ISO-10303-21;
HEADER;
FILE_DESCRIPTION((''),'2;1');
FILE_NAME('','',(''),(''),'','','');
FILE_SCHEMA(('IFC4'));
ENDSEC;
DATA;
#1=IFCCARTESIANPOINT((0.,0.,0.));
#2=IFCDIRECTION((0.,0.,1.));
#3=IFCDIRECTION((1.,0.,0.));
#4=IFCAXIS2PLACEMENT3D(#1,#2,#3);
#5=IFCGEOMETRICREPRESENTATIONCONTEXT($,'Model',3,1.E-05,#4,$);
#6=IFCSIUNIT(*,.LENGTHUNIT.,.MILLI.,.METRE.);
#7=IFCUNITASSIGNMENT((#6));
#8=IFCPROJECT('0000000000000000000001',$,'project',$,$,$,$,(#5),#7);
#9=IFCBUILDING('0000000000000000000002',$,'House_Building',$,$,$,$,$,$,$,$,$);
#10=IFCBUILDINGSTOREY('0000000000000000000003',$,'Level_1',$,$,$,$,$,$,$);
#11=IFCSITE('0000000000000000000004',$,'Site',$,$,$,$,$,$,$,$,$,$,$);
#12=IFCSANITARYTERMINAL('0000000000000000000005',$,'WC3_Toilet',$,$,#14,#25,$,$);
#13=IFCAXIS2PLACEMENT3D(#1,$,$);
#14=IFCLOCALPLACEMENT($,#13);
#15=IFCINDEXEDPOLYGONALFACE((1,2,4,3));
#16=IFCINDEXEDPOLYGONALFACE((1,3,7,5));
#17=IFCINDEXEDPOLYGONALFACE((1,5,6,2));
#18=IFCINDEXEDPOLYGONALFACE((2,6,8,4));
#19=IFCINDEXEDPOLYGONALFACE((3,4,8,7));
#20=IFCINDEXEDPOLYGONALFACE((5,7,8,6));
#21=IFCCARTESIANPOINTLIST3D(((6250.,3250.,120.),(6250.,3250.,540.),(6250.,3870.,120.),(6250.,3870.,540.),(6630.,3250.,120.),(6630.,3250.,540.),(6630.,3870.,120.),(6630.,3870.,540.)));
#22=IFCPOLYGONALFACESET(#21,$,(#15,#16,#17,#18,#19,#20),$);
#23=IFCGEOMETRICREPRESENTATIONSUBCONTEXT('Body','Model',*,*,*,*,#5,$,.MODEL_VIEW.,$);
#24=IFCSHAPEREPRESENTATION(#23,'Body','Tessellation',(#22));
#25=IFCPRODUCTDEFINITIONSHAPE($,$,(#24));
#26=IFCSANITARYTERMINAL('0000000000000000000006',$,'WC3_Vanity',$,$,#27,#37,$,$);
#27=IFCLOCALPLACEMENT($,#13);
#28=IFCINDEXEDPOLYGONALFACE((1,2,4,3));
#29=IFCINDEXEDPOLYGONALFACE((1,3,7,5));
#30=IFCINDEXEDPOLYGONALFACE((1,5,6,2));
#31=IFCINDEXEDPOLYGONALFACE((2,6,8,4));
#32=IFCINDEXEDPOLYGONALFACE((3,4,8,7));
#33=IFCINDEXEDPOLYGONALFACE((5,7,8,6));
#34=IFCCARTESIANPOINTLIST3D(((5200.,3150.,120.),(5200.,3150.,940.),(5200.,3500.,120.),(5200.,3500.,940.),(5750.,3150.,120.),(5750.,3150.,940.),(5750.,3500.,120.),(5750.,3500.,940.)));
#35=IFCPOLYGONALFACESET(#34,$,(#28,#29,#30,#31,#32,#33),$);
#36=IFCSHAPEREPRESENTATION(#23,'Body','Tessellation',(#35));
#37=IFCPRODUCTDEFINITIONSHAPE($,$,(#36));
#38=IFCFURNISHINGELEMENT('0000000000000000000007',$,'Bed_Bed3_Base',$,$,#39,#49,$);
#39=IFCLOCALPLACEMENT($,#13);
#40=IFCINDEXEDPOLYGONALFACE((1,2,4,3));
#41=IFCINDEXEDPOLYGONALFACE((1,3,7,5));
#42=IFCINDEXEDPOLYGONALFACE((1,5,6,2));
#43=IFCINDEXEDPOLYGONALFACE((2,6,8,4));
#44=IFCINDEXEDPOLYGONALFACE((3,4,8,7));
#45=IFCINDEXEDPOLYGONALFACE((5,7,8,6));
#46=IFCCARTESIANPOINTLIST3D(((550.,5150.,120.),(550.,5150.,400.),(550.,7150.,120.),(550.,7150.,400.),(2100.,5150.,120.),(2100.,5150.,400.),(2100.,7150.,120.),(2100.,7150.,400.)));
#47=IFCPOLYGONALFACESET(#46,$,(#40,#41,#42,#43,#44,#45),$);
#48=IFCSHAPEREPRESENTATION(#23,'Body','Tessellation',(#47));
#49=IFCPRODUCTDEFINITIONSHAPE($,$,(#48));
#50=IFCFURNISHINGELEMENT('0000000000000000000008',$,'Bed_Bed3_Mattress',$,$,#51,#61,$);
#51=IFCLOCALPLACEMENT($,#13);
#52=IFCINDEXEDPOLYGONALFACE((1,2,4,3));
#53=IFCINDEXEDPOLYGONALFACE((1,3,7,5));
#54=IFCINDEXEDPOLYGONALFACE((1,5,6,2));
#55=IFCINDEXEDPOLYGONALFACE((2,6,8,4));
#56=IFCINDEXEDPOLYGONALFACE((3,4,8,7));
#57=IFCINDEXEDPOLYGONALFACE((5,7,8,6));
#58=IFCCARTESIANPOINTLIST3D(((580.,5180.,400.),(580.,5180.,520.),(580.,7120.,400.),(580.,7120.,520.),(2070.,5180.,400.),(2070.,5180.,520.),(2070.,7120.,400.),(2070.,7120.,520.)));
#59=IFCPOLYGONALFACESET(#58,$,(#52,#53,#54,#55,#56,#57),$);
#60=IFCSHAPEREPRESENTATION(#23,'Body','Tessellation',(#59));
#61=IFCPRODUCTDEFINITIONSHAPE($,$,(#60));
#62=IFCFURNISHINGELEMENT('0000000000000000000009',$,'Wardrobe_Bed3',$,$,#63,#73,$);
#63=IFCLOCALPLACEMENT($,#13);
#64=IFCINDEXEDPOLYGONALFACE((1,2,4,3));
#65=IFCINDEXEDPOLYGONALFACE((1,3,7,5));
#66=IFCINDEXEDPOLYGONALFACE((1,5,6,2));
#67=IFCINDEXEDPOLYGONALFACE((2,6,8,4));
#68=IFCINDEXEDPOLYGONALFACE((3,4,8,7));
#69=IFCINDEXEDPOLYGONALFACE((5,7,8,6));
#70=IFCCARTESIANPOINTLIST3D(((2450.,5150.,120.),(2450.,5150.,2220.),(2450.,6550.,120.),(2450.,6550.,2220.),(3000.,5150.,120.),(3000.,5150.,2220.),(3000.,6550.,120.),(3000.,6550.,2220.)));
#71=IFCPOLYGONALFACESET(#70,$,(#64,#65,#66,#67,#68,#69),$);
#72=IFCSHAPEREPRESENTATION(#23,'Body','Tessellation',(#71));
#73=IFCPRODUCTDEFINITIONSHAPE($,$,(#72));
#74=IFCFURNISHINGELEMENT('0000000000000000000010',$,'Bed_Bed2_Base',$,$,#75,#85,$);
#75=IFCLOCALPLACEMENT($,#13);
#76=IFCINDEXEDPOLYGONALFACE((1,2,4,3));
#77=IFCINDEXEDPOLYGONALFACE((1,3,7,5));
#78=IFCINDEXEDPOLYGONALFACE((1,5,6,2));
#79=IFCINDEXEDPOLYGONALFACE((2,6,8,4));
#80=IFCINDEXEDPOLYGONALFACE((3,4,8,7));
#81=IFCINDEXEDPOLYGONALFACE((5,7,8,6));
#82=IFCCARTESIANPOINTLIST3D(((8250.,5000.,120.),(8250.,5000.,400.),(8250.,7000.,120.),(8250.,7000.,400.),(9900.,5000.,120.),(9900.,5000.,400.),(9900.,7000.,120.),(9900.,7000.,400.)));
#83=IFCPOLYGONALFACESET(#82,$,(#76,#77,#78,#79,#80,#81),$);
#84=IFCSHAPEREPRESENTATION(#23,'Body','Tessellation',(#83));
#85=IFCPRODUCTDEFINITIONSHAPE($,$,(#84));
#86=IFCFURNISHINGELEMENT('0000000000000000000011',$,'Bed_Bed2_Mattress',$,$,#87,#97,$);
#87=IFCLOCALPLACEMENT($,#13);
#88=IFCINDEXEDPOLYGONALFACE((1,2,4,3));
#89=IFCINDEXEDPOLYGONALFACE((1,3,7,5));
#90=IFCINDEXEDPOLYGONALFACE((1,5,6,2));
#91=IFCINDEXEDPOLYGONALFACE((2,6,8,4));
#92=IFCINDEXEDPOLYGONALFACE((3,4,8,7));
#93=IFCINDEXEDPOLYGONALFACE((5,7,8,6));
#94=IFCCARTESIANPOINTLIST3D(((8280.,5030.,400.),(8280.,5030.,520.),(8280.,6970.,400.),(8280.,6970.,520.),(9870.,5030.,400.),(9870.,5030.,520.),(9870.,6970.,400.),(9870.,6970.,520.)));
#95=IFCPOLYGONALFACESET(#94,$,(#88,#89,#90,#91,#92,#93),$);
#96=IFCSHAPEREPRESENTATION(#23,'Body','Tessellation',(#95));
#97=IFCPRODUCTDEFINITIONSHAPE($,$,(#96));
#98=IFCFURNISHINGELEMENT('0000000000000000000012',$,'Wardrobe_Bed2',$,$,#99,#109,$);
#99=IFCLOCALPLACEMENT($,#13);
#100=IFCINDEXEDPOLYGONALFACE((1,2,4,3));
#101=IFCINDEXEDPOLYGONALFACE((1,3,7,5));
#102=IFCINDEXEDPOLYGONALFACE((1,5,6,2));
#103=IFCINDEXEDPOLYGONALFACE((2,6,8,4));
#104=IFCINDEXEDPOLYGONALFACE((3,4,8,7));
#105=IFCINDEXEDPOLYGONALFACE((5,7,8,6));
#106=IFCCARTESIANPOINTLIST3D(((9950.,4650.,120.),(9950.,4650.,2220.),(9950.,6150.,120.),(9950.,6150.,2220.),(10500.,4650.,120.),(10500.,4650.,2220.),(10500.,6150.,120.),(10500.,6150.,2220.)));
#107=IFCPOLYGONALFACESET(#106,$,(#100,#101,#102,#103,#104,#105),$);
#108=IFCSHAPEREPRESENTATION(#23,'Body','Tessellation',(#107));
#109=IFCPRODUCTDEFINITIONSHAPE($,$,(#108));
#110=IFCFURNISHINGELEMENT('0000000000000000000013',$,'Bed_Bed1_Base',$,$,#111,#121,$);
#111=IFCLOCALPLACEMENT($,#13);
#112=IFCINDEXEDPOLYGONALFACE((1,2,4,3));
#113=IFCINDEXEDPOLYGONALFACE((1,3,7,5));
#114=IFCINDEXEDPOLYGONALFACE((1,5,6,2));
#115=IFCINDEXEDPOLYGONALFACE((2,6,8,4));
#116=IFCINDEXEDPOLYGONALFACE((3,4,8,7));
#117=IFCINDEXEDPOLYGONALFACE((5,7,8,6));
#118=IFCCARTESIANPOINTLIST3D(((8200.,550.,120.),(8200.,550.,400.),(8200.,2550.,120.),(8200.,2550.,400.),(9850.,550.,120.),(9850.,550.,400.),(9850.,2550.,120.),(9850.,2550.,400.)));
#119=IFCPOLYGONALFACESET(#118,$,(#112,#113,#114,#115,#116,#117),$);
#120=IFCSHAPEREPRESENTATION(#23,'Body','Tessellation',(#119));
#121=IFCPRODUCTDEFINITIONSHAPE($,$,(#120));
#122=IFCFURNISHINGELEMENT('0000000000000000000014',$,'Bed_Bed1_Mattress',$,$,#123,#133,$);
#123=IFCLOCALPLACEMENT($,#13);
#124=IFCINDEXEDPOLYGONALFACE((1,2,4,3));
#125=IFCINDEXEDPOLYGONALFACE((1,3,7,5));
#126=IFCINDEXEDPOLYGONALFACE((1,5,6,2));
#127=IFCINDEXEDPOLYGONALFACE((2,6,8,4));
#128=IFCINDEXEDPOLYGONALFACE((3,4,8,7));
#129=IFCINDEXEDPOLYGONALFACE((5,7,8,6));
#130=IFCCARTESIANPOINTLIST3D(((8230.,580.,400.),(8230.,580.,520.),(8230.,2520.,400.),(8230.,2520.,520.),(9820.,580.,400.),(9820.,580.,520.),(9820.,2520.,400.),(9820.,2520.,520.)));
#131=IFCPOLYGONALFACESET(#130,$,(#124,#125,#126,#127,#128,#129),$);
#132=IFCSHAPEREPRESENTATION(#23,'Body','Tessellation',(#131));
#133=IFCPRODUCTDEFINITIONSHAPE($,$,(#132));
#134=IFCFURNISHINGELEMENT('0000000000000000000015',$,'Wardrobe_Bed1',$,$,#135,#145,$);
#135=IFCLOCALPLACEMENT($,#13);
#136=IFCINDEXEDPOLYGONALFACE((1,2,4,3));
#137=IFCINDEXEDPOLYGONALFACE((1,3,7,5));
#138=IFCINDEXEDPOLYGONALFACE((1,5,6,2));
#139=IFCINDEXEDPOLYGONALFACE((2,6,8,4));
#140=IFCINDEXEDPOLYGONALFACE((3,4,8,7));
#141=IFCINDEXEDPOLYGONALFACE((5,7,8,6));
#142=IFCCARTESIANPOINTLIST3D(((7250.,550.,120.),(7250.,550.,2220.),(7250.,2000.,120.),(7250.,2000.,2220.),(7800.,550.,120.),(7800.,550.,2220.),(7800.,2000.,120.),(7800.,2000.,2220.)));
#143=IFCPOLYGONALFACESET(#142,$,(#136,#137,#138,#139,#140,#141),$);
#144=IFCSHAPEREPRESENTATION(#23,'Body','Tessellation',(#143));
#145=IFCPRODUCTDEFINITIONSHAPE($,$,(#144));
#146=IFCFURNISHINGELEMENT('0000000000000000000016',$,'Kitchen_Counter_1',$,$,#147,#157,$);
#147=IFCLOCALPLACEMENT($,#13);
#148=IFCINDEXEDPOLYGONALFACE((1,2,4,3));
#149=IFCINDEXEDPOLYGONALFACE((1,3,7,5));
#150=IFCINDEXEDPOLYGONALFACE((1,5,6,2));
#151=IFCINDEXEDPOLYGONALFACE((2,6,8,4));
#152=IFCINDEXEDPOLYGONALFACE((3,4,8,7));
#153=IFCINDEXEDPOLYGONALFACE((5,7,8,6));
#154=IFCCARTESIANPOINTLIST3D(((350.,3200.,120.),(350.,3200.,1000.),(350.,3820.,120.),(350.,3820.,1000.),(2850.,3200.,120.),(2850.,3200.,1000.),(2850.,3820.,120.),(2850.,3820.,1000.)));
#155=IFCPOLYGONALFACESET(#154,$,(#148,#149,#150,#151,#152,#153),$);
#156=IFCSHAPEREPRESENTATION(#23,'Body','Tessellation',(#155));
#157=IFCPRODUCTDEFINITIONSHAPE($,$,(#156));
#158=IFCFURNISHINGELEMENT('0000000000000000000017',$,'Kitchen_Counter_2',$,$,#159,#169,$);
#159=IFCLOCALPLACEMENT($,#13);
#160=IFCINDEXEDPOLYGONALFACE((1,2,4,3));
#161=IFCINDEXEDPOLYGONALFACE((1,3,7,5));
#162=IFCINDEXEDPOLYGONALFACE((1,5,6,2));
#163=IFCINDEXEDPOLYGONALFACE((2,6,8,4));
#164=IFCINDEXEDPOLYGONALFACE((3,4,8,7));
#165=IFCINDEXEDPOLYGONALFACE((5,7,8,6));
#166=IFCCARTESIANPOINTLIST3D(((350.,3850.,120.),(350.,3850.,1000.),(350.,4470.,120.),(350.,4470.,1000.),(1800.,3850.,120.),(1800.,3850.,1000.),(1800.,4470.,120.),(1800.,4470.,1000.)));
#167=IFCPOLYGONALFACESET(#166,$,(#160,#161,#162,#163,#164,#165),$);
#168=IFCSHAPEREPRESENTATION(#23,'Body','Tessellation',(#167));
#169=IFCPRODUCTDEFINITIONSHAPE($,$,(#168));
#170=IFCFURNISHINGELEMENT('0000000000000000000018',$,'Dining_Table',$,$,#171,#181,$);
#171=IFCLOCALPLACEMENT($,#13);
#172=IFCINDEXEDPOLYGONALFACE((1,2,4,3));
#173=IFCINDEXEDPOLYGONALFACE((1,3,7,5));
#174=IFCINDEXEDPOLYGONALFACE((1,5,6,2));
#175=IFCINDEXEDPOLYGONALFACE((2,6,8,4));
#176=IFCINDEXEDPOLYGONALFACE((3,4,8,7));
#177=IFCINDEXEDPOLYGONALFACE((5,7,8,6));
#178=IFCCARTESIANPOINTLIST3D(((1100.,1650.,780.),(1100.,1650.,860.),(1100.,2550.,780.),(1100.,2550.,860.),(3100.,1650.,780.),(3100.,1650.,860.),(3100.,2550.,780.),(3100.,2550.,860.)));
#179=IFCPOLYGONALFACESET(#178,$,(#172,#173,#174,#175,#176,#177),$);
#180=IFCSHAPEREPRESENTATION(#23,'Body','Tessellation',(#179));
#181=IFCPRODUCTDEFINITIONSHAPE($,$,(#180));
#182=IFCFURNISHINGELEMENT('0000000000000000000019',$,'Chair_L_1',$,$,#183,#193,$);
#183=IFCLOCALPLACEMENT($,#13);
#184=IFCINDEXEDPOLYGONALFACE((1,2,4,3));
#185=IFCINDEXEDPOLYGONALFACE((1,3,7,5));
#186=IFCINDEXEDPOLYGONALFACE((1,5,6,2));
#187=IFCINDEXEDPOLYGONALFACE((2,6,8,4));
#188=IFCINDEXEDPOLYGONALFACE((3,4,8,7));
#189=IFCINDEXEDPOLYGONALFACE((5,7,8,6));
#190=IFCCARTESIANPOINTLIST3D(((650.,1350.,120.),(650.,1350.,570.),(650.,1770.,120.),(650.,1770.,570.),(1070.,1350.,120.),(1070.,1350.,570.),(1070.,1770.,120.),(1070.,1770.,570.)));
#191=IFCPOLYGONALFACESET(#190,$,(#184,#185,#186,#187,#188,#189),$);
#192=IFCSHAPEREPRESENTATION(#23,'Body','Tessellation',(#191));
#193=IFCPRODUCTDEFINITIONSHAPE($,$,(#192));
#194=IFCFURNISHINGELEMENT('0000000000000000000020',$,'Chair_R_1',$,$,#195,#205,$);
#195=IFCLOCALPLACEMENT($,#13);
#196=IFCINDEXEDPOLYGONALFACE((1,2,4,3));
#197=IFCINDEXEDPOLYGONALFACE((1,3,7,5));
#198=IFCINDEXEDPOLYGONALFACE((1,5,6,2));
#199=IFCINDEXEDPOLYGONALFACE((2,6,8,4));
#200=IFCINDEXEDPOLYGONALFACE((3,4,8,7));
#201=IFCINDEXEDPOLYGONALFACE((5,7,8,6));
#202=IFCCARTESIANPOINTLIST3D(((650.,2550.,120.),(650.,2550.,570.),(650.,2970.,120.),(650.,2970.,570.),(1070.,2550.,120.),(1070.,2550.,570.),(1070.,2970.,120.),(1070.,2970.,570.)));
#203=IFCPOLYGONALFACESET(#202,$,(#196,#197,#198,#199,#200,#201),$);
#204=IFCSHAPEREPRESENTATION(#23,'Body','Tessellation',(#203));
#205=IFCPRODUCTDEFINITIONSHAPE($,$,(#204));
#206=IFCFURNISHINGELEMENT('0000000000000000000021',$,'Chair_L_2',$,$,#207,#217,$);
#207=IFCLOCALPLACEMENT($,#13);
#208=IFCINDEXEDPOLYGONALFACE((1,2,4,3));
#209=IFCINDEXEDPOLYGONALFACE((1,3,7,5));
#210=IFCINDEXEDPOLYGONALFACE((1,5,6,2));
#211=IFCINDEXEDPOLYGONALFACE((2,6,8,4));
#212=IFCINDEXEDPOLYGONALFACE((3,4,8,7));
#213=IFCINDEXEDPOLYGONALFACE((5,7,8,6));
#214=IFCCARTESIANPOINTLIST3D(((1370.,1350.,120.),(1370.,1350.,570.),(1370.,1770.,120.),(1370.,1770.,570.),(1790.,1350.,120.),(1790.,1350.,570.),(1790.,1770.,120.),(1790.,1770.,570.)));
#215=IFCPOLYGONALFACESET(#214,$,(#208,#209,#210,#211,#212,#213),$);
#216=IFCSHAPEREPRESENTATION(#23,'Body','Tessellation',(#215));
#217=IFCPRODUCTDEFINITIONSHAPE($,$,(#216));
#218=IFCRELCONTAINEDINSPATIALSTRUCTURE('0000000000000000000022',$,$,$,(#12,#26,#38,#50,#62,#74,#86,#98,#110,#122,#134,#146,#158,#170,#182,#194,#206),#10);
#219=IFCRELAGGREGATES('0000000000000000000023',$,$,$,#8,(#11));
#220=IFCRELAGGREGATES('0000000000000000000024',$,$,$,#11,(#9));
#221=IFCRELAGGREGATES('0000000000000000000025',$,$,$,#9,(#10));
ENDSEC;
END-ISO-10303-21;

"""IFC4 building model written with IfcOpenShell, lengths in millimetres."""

from ifc_helpers import new_model, si_unit, frame, origin_with_axes, context, subcontext, project, spatial, polyline, outline, extrude, element, save


model = new_model("IFC4")

# Units and contexts
model_context = context("Model", 3, precision=1e-05, world=origin_with_axes())
body_context = subcontext(model_context, "Body", "Model", "MODEL_VIEW")
ifc_project = project(units=[si_unit("LENGTHUNIT", "METRE", prefix="MILLI")], contexts=[model_context])

# Site, building, storey
site = spatial("IfcSite", under=ifc_project, Name="Site")
building = spatial("IfcBuilding", under=site, Name="House_Building")
storey = spatial("IfcBuildingStorey", under=building, Name="Level_1")

# Sanitary terminals
element("IfcSanitaryTerminal", 1, inside=storey, Name="WC3_Toilet", context=body_context, shape_type="SweptSolid", body=[
    extrude(outline(polyline([(6250.0, 3250.0), (6630.0, 3250.0), (6630.0, 3870.0), (6250.0, 3870.0), (6250.0, 3250.0)])), frame((0.0, 0.0, 120.0), z_axis=(0.0, 0.0, 1.0), x_axis=(1.0, 0.0, 0.0)), (0.0, 0.0, 1.0), 420.0),
])
element("IfcSanitaryTerminal", 2, inside=storey, Name="WC3_Vanity", context=body_context, shape_type="SweptSolid", body=[
    extrude(outline(polyline([(5200.0, 3150.0), (5750.0, 3150.0), (5750.0, 3500.0), (5200.0, 3500.0), (5200.0, 3150.0)])), frame((0.0, 0.0, 120.0), z_axis=(0.0, 0.0, 1.0), x_axis=(1.0, 0.0, 0.0)), (0.0, 0.0, 1.0), 820.0),
])

# Furnishing elements
element("IfcFurnishingElement", 3, inside=storey, Name="Bed_Bed3_Base", context=body_context, shape_type="SweptSolid", body=[
    extrude(outline(polyline([(550.0, 5150.0), (2100.0, 5150.0), (2100.0, 7150.0), (550.0, 7150.0), (550.0, 5150.0)])), frame((0.0, 0.0, 120.0), z_axis=(0.0, 0.0, 1.0), x_axis=(1.0, 0.0, 0.0)), (0.0, 0.0, 1.0), 280.0),
])
element("IfcFurnishingElement", 4, inside=storey, Name="Bed_Bed3_Mattress", context=body_context, shape_type="SweptSolid", body=[
    extrude(outline(polyline([(580.0, 5180.0), (2070.0, 5180.0), (2070.0, 7120.0), (580.0, 7120.0), (580.0, 5180.0)])), frame((0.0, 0.0, 400.0), z_axis=(0.0, 0.0, 1.0), x_axis=(1.0, 0.0, 0.0)), (0.0, 0.0, 1.0), 120.0),
])
element("IfcFurnishingElement", 5, inside=storey, Name="Wardrobe_Bed3", context=body_context, shape_type="SweptSolid", body=[
    extrude(outline(polyline([(2450.0, 5150.0), (3000.0, 5150.0), (3000.0, 6550.0), (2450.0, 6550.0), (2450.0, 5150.0)])), frame((0.0, 0.0, 120.0), z_axis=(0.0, 0.0, 1.0), x_axis=(1.0, 0.0, 0.0)), (0.0, 0.0, 1.0), 2100.0),
])
element("IfcFurnishingElement", 6, inside=storey, Name="Bed_Bed2_Base", context=body_context, shape_type="SweptSolid", body=[
    extrude(outline(polyline([(8250.0, 5000.0), (9900.0, 5000.0), (9900.0, 7000.0), (8250.0, 7000.0), (8250.0, 5000.0)])), frame((0.0, 0.0, 120.0), z_axis=(0.0, 0.0, 1.0), x_axis=(1.0, 0.0, 0.0)), (0.0, 0.0, 1.0), 280.0),
])
element("IfcFurnishingElement", 7, inside=storey, Name="Bed_Bed2_Mattress", context=body_context, shape_type="SweptSolid", body=[
    extrude(outline(polyline([(8280.0, 5030.0), (9870.0, 5030.0), (9870.0, 6970.0), (8280.0, 6970.0), (8280.0, 5030.0)])), frame((0.0, 0.0, 400.0), z_axis=(0.0, 0.0, 1.0), x_axis=(1.0, 0.0, 0.0)), (0.0, 0.0, 1.0), 120.0),
])
element("IfcFurnishingElement", 8, inside=storey, Name="Wardrobe_Bed2", context=body_context, shape_type="SweptSolid", body=[
    extrude(outline(polyline([(9950.0, 4650.0), (10500.0, 4650.0), (10500.0, 6150.0), (9950.0, 6150.0), (9950.0, 4650.0)])), frame((0.0, 0.0, 120.0), z_axis=(0.0, 0.0, 1.0), x_axis=(1.0, 0.0, 0.0)), (0.0, 0.0, 1.0), 2100.0),
])
element("IfcFurnishingElement", 9, inside=storey, Name="Bed_Bed1_Base", context=body_context, shape_type="SweptSolid", body=[
    extrude(outline(polyline([(8200.0, 550.0), (9850.0, 550.0), (9850.0, 2550.0), (8200.0, 2550.0), (8200.0, 550.0)])), frame((0.0, 0.0, 120.0), z_axis=(0.0, 0.0, 1.0), x_axis=(1.0, 0.0, 0.0)), (0.0, 0.0, 1.0), 280.0),
])
element("IfcFurnishingElement", 10, inside=storey, Name="Bed_Bed1_Mattress", context=body_context, shape_type="SweptSolid", body=[
    extrude(outline(polyline([(8230.0, 580.0), (9820.0, 580.0), (9820.0, 2520.0), (8230.0, 2520.0), (8230.0, 580.0)])), frame((0.0, 0.0, 400.0), z_axis=(0.0, 0.0, 1.0), x_axis=(1.0, 0.0, 0.0)), (0.0, 0.0, 1.0), 120.0),
])
element("IfcFurnishingElement", 11, inside=storey, Name="Wardrobe_Bed1", context=body_context, shape_type="SweptSolid", body=[
    extrude(outline(polyline([(7250.0, 550.0), (7800.0, 550.0), (7800.0, 2000.0), (7250.0, 2000.0), (7250.0, 550.0)])), frame((0.0, 0.0, 120.0), z_axis=(0.0, 0.0, 1.0), x_axis=(1.0, 0.0, 0.0)), (0.0, 0.0, 1.0), 2100.0),
])
element("IfcFurnishingElement", 12, inside=storey, Name="Kitchen_Counter_1", context=body_context, shape_type="SweptSolid", body=[
    extrude(outline(polyline([(350.0, 3200.0), (2850.0, 3200.0), (2850.0, 3820.0), (350.0, 3820.0), (350.0, 3200.0)])), frame((0.0, 0.0, 120.0), z_axis=(0.0, 0.0, 1.0), x_axis=(1.0, 0.0, 0.0)), (0.0, 0.0, 1.0), 880.0),
])
element("IfcFurnishingElement", 13, inside=storey, Name="Kitchen_Counter_2", context=body_context, shape_type="SweptSolid", body=[
    extrude(outline(polyline([(350.0, 3850.0), (1800.0, 3850.0), (1800.0, 4470.0), (350.0, 4470.0), (350.0, 3850.0)])), frame((0.0, 0.0, 120.0), z_axis=(0.0, 0.0, 1.0), x_axis=(1.0, 0.0, 0.0)), (0.0, 0.0, 1.0), 880.0),
])
element("IfcFurnishingElement", 14, inside=storey, Name="Dining_Table", context=body_context, shape_type="SweptSolid", body=[
    extrude(outline(polyline([(1100.0, 1650.0), (3100.0, 1650.0), (3100.0, 2550.0), (1100.0, 2550.0), (1100.0, 1650.0)])), frame((0.0, 0.0, 780.0), z_axis=(0.0, 0.0, 1.0), x_axis=(1.0, 0.0, 0.0)), (0.0, 0.0, 1.0), 80.0),
])
element("IfcFurnishingElement", 15, inside=storey, Name="Chair_L_1", context=body_context, shape_type="SweptSolid", body=[
    extrude(outline(polyline([(650.0, 1350.0), (1070.0, 1350.0), (1070.0, 1770.0), (650.0, 1770.0), (650.0, 1350.0)])), frame((0.0, 0.0, 120.0), z_axis=(0.0, 0.0, 1.0), x_axis=(1.0, 0.0, 0.0)), (0.0, 0.0, 1.0), 450.0),
])
element("IfcFurnishingElement", 16, inside=storey, Name="Chair_R_1", context=body_context, shape_type="SweptSolid", body=[
    extrude(outline(polyline([(650.0, 2550.0), (1070.0, 2550.0), (1070.0, 2970.0), (650.0, 2970.0), (650.0, 2550.0)])), frame((0.0, 0.0, 120.0), z_axis=(0.0, 0.0, 1.0), x_axis=(1.0, 0.0, 0.0)), (0.0, 0.0, 1.0), 450.0),
])
element("IfcFurnishingElement", 17, inside=storey, Name="Chair_L_2", context=body_context, shape_type="SweptSolid", body=[
    extrude(outline(polyline([(1370.0, 1350.0), (1790.0, 1350.0), (1790.0, 1770.0), (1370.0, 1770.0), (1370.0, 1350.0)])), frame((0.0, 0.0, 120.0), z_axis=(0.0, 0.0, 1.0), x_axis=(1.0, 0.0, 0.0)), (0.0, 0.0, 1.0), 450.0),
])

save(model, "model.ifc")
